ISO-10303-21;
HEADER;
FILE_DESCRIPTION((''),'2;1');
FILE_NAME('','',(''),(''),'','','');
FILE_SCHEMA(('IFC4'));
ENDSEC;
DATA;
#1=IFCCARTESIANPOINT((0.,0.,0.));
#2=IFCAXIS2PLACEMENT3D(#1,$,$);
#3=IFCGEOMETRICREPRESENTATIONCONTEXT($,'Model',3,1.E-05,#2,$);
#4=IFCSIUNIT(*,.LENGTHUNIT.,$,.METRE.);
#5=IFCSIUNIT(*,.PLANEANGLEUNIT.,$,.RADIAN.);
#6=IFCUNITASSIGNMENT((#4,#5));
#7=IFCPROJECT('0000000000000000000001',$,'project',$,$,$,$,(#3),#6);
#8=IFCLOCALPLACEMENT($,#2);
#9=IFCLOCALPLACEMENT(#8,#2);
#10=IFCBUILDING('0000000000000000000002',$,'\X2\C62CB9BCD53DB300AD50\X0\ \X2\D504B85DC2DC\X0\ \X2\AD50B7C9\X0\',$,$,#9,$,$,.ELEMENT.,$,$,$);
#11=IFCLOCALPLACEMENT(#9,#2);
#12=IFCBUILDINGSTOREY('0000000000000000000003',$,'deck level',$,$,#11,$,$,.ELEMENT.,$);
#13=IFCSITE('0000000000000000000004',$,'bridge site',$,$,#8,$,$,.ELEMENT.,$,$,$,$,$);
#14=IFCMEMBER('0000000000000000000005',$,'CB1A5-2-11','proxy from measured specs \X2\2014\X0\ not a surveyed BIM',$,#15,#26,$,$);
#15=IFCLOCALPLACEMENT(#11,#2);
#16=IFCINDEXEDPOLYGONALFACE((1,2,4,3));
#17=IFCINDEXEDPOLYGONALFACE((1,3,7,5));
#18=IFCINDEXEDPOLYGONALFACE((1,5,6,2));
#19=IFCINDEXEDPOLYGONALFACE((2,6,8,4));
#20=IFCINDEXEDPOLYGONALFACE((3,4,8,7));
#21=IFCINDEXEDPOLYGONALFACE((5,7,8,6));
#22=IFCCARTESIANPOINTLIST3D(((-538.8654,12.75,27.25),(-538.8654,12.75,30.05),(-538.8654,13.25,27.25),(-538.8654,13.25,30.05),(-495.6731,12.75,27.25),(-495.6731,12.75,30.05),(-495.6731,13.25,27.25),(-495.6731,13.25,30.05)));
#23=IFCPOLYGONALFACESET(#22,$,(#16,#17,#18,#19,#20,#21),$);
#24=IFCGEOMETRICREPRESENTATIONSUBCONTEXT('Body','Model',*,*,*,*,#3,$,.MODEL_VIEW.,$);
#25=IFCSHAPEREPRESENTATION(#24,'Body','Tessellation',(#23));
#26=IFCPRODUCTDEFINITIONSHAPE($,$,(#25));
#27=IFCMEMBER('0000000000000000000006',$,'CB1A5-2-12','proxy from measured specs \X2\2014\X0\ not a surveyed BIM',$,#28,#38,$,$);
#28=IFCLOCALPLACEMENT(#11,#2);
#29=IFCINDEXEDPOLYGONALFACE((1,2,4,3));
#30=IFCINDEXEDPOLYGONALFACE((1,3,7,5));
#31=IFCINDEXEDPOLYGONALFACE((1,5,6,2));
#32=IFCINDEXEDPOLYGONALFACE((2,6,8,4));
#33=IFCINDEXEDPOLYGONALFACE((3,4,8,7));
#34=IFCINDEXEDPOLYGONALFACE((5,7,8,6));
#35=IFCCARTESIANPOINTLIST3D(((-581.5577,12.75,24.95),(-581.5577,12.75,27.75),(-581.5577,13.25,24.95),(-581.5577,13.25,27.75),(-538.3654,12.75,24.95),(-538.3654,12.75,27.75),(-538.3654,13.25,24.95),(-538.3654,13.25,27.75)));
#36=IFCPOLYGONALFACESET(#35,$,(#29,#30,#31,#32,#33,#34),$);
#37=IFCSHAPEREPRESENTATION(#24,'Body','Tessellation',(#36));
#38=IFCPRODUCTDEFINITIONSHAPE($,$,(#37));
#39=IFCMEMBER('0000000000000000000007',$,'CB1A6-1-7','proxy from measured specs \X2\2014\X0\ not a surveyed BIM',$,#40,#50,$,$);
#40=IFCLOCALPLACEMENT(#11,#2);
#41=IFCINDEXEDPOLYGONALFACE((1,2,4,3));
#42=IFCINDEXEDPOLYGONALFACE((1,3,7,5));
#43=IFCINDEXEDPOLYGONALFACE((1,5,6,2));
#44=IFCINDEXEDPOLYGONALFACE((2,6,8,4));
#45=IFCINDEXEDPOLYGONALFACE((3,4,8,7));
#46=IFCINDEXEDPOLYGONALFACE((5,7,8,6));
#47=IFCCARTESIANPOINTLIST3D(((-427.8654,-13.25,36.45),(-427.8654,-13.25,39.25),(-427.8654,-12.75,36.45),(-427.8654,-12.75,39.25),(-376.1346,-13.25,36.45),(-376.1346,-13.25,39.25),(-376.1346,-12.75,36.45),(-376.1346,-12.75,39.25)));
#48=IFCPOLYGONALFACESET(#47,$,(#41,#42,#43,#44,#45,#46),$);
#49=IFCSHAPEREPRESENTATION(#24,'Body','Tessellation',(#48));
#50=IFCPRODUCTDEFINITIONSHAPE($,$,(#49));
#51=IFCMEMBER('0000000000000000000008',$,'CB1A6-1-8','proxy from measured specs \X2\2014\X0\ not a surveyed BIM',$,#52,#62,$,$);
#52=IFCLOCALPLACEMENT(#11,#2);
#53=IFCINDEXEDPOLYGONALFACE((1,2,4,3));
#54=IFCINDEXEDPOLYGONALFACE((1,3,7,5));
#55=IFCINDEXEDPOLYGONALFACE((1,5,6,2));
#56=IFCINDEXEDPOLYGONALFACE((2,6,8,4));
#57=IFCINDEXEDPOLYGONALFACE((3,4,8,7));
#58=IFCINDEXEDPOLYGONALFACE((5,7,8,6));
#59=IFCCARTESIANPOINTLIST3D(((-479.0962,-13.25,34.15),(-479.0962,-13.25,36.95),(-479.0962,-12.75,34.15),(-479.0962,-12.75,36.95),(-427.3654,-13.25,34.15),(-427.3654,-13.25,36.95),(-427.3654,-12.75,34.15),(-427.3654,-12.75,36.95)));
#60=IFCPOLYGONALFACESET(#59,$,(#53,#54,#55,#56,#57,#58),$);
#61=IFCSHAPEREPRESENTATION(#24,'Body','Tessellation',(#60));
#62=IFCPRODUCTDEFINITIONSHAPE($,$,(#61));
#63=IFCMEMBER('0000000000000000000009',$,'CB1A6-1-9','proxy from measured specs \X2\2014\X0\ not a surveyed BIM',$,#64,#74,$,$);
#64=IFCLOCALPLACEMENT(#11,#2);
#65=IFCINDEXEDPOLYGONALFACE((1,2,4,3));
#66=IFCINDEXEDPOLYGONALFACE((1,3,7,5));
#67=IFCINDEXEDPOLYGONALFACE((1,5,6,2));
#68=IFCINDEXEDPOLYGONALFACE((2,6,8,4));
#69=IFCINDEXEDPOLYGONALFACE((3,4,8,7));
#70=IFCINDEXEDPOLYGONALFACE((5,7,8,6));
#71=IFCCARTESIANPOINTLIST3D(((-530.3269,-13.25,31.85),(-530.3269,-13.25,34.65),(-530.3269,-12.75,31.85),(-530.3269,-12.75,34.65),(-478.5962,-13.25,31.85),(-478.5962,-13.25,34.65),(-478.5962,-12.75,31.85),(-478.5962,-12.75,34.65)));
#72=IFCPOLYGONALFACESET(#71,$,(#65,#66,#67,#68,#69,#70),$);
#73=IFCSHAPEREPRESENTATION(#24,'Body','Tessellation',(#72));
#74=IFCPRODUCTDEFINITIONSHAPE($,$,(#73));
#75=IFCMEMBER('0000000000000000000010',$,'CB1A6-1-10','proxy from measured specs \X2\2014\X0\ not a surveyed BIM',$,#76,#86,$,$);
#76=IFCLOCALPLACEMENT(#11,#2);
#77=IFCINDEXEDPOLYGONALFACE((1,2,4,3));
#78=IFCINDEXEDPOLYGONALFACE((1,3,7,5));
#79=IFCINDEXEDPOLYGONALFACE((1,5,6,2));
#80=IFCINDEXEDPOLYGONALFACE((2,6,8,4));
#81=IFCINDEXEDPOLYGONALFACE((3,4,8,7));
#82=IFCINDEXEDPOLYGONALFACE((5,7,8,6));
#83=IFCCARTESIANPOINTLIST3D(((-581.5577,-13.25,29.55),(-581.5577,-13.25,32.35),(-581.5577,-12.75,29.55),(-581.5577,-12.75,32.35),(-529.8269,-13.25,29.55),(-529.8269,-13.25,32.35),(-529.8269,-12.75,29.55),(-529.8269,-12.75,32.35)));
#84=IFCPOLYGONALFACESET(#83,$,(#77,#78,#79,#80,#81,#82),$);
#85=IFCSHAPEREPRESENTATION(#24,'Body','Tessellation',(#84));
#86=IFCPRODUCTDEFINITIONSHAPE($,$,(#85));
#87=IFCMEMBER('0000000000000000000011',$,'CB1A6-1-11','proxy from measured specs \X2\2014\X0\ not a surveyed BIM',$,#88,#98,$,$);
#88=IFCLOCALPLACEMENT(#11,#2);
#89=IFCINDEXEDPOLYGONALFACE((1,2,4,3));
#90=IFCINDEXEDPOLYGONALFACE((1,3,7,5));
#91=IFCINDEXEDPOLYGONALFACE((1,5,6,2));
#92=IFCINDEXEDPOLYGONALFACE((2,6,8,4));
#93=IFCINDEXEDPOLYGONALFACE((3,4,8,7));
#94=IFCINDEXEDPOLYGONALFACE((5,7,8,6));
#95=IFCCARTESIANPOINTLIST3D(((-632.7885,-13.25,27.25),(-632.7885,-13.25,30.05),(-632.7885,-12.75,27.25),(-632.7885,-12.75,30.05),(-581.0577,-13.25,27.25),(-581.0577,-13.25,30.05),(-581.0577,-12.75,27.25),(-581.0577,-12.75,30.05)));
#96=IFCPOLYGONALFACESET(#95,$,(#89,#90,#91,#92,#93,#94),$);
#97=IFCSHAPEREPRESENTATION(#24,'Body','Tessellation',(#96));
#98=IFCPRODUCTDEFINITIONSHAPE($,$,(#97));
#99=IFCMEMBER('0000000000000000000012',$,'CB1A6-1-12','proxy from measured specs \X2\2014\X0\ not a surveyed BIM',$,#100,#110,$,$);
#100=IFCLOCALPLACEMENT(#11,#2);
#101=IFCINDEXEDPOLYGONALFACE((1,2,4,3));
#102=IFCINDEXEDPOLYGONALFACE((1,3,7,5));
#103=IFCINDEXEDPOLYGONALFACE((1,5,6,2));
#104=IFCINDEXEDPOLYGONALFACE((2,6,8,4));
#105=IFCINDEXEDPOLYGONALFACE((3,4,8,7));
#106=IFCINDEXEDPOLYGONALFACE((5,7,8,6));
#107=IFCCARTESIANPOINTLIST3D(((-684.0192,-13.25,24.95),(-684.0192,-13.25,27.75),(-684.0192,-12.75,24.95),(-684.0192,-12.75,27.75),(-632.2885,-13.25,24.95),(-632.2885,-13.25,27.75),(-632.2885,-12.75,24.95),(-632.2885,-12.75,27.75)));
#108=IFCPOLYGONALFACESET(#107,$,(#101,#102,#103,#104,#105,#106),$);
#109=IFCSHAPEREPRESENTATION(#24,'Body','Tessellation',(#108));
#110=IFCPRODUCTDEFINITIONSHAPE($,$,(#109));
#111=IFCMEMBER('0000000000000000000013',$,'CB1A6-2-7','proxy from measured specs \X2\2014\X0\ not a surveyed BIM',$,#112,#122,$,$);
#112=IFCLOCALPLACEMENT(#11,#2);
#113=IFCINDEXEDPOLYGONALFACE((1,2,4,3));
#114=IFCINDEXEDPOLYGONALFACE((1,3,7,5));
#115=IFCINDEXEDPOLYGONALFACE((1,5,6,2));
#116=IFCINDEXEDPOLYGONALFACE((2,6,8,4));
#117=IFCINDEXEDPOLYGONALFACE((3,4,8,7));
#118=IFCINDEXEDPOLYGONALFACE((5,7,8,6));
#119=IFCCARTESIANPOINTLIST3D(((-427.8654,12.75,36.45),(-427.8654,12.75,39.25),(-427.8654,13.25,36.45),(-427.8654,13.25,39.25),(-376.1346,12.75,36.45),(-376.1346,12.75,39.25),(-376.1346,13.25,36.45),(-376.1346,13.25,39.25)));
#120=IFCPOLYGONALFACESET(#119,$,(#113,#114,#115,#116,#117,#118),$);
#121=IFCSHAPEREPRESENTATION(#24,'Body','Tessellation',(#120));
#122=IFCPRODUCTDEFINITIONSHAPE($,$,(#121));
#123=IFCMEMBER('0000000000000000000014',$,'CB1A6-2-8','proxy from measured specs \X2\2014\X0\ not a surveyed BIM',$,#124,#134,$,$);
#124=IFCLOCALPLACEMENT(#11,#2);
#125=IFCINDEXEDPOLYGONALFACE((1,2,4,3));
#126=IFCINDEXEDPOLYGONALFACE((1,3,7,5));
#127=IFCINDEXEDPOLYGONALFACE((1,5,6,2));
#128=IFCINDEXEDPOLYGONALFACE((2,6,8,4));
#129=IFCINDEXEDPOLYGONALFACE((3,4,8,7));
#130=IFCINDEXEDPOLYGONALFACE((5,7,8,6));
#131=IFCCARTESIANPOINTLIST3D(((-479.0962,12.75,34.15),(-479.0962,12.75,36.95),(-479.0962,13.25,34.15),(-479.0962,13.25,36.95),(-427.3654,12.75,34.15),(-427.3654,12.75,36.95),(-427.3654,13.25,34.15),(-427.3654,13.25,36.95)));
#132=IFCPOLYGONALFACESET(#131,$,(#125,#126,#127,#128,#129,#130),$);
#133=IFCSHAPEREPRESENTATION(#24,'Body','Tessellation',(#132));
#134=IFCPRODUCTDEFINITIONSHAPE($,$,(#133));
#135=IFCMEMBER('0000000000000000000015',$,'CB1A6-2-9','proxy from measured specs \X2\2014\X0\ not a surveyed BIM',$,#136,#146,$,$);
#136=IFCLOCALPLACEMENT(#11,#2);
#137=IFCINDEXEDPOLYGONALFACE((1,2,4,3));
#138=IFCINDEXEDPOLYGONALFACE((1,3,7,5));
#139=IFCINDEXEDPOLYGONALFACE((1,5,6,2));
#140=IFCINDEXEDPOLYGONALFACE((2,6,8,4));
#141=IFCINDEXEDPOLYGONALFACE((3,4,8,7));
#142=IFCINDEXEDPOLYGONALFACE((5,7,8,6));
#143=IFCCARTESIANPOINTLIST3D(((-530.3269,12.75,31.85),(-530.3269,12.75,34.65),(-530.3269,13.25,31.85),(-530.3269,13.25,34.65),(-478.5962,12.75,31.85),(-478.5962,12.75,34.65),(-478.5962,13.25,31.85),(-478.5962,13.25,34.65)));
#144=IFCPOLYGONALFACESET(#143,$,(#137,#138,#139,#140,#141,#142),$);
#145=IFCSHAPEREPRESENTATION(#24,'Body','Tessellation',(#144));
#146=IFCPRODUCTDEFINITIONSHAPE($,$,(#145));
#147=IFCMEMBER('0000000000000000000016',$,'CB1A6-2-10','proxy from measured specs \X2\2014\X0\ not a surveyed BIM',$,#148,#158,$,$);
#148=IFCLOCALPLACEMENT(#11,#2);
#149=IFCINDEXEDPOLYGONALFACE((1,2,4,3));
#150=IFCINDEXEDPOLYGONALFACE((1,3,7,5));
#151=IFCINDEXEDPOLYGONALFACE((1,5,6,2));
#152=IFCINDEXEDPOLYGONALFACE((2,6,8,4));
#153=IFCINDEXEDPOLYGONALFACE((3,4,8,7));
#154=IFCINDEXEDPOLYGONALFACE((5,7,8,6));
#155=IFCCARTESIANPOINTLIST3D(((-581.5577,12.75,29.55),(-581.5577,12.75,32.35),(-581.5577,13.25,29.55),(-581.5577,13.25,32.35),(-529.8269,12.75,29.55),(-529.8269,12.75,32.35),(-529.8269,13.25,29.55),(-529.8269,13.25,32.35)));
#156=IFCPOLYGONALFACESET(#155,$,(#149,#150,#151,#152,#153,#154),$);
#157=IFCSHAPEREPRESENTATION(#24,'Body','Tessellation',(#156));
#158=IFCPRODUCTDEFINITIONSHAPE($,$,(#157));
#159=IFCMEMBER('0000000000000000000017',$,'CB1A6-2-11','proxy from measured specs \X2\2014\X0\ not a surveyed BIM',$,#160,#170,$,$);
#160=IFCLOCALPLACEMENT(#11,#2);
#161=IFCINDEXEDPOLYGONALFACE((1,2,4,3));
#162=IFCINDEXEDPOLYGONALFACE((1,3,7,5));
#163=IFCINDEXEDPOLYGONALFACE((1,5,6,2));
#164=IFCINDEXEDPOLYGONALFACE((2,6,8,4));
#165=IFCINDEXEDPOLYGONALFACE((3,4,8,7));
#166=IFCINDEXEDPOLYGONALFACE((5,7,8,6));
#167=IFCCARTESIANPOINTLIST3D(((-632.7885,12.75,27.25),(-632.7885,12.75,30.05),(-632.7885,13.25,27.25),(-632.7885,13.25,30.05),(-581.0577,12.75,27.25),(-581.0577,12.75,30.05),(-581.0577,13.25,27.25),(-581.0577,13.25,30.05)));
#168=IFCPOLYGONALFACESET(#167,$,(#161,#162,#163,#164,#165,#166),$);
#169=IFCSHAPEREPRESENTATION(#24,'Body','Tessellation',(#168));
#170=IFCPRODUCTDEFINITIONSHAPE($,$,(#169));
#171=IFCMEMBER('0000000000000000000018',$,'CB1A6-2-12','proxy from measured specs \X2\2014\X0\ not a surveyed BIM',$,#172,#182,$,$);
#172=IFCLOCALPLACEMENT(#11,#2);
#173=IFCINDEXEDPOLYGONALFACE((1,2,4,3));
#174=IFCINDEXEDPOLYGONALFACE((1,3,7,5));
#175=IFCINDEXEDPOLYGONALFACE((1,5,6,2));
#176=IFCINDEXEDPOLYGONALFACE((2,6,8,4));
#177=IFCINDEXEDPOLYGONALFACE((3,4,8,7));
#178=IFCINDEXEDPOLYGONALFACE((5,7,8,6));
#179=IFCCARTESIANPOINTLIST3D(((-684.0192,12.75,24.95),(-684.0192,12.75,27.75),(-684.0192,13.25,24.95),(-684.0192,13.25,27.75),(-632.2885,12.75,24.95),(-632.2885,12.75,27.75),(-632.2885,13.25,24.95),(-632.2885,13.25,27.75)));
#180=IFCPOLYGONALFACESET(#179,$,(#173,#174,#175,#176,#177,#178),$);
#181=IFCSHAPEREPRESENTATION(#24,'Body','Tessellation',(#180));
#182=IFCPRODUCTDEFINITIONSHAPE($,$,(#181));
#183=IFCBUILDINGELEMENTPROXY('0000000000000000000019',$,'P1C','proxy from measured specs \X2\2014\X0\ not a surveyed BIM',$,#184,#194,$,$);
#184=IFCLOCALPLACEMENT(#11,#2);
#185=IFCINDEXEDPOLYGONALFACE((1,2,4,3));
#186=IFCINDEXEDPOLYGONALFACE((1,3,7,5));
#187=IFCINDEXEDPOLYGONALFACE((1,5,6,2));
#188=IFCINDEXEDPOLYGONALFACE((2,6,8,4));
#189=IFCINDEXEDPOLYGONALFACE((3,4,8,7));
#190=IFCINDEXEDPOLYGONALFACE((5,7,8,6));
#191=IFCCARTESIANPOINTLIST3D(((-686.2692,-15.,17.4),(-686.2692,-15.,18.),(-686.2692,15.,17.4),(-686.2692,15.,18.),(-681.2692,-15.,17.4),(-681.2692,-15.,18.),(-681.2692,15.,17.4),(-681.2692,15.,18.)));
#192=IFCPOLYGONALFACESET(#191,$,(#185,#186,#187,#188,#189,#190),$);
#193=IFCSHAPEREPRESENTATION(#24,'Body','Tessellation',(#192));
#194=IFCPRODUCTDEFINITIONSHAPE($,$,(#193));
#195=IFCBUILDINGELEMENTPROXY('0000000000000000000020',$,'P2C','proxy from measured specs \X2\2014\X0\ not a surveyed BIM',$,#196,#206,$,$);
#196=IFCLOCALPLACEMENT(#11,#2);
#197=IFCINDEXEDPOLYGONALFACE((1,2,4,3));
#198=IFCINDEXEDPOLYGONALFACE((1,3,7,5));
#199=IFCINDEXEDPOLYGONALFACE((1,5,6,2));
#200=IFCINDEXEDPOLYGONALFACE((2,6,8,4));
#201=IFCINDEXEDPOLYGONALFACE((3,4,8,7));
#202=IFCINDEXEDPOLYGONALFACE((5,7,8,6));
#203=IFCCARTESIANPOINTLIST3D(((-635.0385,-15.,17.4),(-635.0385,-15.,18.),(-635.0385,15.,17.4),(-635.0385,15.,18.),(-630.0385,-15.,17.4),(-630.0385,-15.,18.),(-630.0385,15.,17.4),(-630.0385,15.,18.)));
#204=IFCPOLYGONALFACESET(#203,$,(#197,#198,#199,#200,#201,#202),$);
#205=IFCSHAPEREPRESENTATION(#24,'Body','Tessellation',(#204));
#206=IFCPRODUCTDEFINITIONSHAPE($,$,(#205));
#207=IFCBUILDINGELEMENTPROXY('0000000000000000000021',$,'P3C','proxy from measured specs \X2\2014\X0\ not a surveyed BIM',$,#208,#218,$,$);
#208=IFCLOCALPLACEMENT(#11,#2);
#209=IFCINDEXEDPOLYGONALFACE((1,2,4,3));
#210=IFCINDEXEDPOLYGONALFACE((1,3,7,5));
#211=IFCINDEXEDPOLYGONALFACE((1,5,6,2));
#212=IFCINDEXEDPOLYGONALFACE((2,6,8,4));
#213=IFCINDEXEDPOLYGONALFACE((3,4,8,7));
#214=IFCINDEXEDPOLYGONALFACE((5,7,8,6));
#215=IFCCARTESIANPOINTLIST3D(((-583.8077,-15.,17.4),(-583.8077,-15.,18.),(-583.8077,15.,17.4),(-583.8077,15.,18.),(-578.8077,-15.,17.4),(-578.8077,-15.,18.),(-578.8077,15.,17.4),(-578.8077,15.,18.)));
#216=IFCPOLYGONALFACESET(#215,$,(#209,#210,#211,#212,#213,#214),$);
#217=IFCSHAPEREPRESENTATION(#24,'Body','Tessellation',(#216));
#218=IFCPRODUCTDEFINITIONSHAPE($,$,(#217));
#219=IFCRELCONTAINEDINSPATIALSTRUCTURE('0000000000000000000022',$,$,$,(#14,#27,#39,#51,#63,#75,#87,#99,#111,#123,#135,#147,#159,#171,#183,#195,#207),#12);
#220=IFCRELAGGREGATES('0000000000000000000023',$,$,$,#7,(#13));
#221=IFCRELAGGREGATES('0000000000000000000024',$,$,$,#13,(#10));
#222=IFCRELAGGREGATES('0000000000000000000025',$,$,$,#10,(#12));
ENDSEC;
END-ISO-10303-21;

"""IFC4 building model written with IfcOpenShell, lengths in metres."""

from ifc_helpers import new_model, si_unit, frame, origin, origin_2d, place, context, subcontext, project, spatial, rectangle, extrude, element, save


model = new_model("IFC4")

# Units and contexts
model_context = context("Model", 3, precision=1e-05, world=origin())
body_context = subcontext(model_context, "Body", "Model", "MODEL_VIEW")
ifc_project = project(units=[si_unit("LENGTHUNIT", "METRE"), si_unit("PLANEANGLEUNIT", "RADIAN")], contexts=[model_context])

# Site, building, storey
site_placement = place(None, origin())
site = spatial("IfcSite", under=ifc_project, at=site_placement, Name="bridge site", CompositionType="ELEMENT")
building_placement = place(site_placement, origin())
building = spatial("IfcBuilding", under=site, at=building_placement, Name="올림픽대교 프록시 교량", CompositionType="ELEMENT")
storey_placement = place(building_placement, origin())
storey = spatial("IfcBuildingStorey", under=building, at=storey_placement, Name="deck level", CompositionType="ELEMENT")

# Members
member_1_placement = place(storey_placement, frame((-517.2692, 13.0, 27.25)))
element("IfcMember", 1, at=member_1_placement, inside=storey, Name="CB1A5-2-11", Description="proxy from measured specs — not a surveyed BIM", context=body_context, shape_type="SweptSolid", body=[
    extrude(rectangle(XDim=43.1923, YDim=0.5, at=origin_2d()), origin(), (0.0, 0.0, 1.0), 2.8),
])
member_2_placement = place(storey_placement, frame((-559.9615, 13.0, 24.95)))
element("IfcMember", 2, at=member_2_placement, inside=storey, Name="CB1A5-2-12", Description="proxy from measured specs — not a surveyed BIM", context=body_context, shape_type="SweptSolid", body=[
    extrude(rectangle(XDim=43.1923, YDim=0.5, at=origin_2d()), origin(), (0.0, 0.0, 1.0), 2.8),
])
member_3_placement = place(storey_placement, frame((-402.0, -13.0, 36.45)))
element("IfcMember", 3, at=member_3_placement, inside=storey, Name="CB1A6-1-7", Description="proxy from measured specs — not a surveyed BIM", context=body_context, shape_type="SweptSolid", body=[
    extrude(rectangle(XDim=51.7308, YDim=0.5, at=origin_2d()), origin(), (0.0, 0.0, 1.0), 2.8),
])
member_4_placement = place(storey_placement, frame((-453.2308, -13.0, 34.15)))
element("IfcMember", 4, at=member_4_placement, inside=storey, Name="CB1A6-1-8", Description="proxy from measured specs — not a surveyed BIM", context=body_context, shape_type="SweptSolid", body=[
    extrude(rectangle(XDim=51.7308, YDim=0.5, at=origin_2d()), origin(), (0.0, 0.0, 1.0), 2.8),
])
member_5_placement = place(storey_placement, frame((-504.4615, -13.0, 31.85)))
element("IfcMember", 5, at=member_5_placement, inside=storey, Name="CB1A6-1-9", Description="proxy from measured specs — not a surveyed BIM", context=body_context, shape_type="SweptSolid", body=[
    extrude(rectangle(XDim=51.7308, YDim=0.5, at=origin_2d()), origin(), (0.0, 0.0, 1.0), 2.8),
])
member_6_placement = place(storey_placement, frame((-555.6923, -13.0, 29.55)))
element("IfcMember", 6, at=member_6_placement, inside=storey, Name="CB1A6-1-10", Description="proxy from measured specs — not a surveyed BIM", context=body_context, shape_type="SweptSolid", body=[
    extrude(rectangle(XDim=51.7308, YDim=0.5, at=origin_2d()), origin(), (0.0, 0.0, 1.0), 2.8),
])
member_7_placement = place(storey_placement, frame((-606.9231, -13.0, 27.25)))
element("IfcMember", 7, at=member_7_placement, inside=storey, Name="CB1A6-1-11", Description="proxy from measured specs — not a surveyed BIM", context=body_context, shape_type="SweptSolid", body=[
    extrude(rectangle(XDim=51.7308, YDim=0.5, at=origin_2d()), origin(), (0.0, 0.0, 1.0), 2.8),
])
member_8_placement = place(storey_placement, frame((-658.1538, -13.0, 24.95)))
element("IfcMember", 8, at=member_8_placement, inside=storey, Name="CB1A6-1-12", Description="proxy from measured specs — not a surveyed BIM", context=body_context, shape_type="SweptSolid", body=[
    extrude(rectangle(XDim=51.7308, YDim=0.5, at=origin_2d()), origin(), (0.0, 0.0, 1.0), 2.8),
])
member_9_placement = place(storey_placement, frame((-402.0, 13.0, 36.45)))
element("IfcMember", 9, at=member_9_placement, inside=storey, Name="CB1A6-2-7", Description="proxy from measured specs — not a surveyed BIM", context=body_context, shape_type="SweptSolid", body=[
    extrude(rectangle(XDim=51.7308, YDim=0.5, at=origin_2d()), origin(), (0.0, 0.0, 1.0), 2.8),
])
member_10_placement = place(storey_placement, frame((-453.2308, 13.0, 34.15)))
element("IfcMember", 10, at=member_10_placement, inside=storey, Name="CB1A6-2-8", Description="proxy from measured specs — not a surveyed BIM", context=body_context, shape_type="SweptSolid", body=[
    extrude(rectangle(XDim=51.7308, YDim=0.5, at=origin_2d()), origin(), (0.0, 0.0, 1.0), 2.8),
])
member_11_placement = place(storey_placement, frame((-504.4615, 13.0, 31.85)))
element("IfcMember", 11, at=member_11_placement, inside=storey, Name="CB1A6-2-9", Description="proxy from measured specs — not a surveyed BIM", context=body_context, shape_type="SweptSolid", body=[
    extrude(rectangle(XDim=51.7308, YDim=0.5, at=origin_2d()), origin(), (0.0, 0.0, 1.0), 2.8),
])
member_12_placement = place(storey_placement, frame((-555.6923, 13.0, 29.55)))
element("IfcMember", 12, at=member_12_placement, inside=storey, Name="CB1A6-2-10", Description="proxy from measured specs — not a surveyed BIM", context=body_context, shape_type="SweptSolid", body=[
    extrude(rectangle(XDim=51.7308, YDim=0.5, at=origin_2d()), origin(), (0.0, 0.0, 1.0), 2.8),
])
member_13_placement = place(storey_placement, frame((-606.9231, 13.0, 27.25)))
element("IfcMember", 13, at=member_13_placement, inside=storey, Name="CB1A6-2-11", Description="proxy from measured specs — not a surveyed BIM", context=body_context, shape_type="SweptSolid", body=[
    extrude(rectangle(XDim=51.7308, YDim=0.5, at=origin_2d()), origin(), (0.0, 0.0, 1.0), 2.8),
])
member_14_placement = place(storey_placement, frame((-658.1538, 13.0, 24.95)))
element("IfcMember", 14, at=member_14_placement, inside=storey, Name="CB1A6-2-12", Description="proxy from measured specs — not a surveyed BIM", context=body_context, shape_type="SweptSolid", body=[
    extrude(rectangle(XDim=51.7308, YDim=0.5, at=origin_2d()), origin(), (0.0, 0.0, 1.0), 2.8),
])

# Building element proxies
for number, where, name in (
    (15, (-683.7692, 0.0, 17.4), "P1C"),
    (16, (-632.5385, 0.0, 17.4), "P2C"),
    (17, (-581.3077, 0.0, 17.4), "P3C"),
):
    element("IfcBuildingElementProxy", number, at=place(storey_placement, frame(where)), inside=storey, Name=name, Description="proxy from measured specs — not a surveyed BIM", context=body_context, shape_type="SweptSolid", body=[
        extrude(rectangle(XDim=5.0, YDim=30.0, at=origin_2d()), origin(), (0.0, 0.0, 1.0), 0.6),
    ])

save(model, "model.ifc")
